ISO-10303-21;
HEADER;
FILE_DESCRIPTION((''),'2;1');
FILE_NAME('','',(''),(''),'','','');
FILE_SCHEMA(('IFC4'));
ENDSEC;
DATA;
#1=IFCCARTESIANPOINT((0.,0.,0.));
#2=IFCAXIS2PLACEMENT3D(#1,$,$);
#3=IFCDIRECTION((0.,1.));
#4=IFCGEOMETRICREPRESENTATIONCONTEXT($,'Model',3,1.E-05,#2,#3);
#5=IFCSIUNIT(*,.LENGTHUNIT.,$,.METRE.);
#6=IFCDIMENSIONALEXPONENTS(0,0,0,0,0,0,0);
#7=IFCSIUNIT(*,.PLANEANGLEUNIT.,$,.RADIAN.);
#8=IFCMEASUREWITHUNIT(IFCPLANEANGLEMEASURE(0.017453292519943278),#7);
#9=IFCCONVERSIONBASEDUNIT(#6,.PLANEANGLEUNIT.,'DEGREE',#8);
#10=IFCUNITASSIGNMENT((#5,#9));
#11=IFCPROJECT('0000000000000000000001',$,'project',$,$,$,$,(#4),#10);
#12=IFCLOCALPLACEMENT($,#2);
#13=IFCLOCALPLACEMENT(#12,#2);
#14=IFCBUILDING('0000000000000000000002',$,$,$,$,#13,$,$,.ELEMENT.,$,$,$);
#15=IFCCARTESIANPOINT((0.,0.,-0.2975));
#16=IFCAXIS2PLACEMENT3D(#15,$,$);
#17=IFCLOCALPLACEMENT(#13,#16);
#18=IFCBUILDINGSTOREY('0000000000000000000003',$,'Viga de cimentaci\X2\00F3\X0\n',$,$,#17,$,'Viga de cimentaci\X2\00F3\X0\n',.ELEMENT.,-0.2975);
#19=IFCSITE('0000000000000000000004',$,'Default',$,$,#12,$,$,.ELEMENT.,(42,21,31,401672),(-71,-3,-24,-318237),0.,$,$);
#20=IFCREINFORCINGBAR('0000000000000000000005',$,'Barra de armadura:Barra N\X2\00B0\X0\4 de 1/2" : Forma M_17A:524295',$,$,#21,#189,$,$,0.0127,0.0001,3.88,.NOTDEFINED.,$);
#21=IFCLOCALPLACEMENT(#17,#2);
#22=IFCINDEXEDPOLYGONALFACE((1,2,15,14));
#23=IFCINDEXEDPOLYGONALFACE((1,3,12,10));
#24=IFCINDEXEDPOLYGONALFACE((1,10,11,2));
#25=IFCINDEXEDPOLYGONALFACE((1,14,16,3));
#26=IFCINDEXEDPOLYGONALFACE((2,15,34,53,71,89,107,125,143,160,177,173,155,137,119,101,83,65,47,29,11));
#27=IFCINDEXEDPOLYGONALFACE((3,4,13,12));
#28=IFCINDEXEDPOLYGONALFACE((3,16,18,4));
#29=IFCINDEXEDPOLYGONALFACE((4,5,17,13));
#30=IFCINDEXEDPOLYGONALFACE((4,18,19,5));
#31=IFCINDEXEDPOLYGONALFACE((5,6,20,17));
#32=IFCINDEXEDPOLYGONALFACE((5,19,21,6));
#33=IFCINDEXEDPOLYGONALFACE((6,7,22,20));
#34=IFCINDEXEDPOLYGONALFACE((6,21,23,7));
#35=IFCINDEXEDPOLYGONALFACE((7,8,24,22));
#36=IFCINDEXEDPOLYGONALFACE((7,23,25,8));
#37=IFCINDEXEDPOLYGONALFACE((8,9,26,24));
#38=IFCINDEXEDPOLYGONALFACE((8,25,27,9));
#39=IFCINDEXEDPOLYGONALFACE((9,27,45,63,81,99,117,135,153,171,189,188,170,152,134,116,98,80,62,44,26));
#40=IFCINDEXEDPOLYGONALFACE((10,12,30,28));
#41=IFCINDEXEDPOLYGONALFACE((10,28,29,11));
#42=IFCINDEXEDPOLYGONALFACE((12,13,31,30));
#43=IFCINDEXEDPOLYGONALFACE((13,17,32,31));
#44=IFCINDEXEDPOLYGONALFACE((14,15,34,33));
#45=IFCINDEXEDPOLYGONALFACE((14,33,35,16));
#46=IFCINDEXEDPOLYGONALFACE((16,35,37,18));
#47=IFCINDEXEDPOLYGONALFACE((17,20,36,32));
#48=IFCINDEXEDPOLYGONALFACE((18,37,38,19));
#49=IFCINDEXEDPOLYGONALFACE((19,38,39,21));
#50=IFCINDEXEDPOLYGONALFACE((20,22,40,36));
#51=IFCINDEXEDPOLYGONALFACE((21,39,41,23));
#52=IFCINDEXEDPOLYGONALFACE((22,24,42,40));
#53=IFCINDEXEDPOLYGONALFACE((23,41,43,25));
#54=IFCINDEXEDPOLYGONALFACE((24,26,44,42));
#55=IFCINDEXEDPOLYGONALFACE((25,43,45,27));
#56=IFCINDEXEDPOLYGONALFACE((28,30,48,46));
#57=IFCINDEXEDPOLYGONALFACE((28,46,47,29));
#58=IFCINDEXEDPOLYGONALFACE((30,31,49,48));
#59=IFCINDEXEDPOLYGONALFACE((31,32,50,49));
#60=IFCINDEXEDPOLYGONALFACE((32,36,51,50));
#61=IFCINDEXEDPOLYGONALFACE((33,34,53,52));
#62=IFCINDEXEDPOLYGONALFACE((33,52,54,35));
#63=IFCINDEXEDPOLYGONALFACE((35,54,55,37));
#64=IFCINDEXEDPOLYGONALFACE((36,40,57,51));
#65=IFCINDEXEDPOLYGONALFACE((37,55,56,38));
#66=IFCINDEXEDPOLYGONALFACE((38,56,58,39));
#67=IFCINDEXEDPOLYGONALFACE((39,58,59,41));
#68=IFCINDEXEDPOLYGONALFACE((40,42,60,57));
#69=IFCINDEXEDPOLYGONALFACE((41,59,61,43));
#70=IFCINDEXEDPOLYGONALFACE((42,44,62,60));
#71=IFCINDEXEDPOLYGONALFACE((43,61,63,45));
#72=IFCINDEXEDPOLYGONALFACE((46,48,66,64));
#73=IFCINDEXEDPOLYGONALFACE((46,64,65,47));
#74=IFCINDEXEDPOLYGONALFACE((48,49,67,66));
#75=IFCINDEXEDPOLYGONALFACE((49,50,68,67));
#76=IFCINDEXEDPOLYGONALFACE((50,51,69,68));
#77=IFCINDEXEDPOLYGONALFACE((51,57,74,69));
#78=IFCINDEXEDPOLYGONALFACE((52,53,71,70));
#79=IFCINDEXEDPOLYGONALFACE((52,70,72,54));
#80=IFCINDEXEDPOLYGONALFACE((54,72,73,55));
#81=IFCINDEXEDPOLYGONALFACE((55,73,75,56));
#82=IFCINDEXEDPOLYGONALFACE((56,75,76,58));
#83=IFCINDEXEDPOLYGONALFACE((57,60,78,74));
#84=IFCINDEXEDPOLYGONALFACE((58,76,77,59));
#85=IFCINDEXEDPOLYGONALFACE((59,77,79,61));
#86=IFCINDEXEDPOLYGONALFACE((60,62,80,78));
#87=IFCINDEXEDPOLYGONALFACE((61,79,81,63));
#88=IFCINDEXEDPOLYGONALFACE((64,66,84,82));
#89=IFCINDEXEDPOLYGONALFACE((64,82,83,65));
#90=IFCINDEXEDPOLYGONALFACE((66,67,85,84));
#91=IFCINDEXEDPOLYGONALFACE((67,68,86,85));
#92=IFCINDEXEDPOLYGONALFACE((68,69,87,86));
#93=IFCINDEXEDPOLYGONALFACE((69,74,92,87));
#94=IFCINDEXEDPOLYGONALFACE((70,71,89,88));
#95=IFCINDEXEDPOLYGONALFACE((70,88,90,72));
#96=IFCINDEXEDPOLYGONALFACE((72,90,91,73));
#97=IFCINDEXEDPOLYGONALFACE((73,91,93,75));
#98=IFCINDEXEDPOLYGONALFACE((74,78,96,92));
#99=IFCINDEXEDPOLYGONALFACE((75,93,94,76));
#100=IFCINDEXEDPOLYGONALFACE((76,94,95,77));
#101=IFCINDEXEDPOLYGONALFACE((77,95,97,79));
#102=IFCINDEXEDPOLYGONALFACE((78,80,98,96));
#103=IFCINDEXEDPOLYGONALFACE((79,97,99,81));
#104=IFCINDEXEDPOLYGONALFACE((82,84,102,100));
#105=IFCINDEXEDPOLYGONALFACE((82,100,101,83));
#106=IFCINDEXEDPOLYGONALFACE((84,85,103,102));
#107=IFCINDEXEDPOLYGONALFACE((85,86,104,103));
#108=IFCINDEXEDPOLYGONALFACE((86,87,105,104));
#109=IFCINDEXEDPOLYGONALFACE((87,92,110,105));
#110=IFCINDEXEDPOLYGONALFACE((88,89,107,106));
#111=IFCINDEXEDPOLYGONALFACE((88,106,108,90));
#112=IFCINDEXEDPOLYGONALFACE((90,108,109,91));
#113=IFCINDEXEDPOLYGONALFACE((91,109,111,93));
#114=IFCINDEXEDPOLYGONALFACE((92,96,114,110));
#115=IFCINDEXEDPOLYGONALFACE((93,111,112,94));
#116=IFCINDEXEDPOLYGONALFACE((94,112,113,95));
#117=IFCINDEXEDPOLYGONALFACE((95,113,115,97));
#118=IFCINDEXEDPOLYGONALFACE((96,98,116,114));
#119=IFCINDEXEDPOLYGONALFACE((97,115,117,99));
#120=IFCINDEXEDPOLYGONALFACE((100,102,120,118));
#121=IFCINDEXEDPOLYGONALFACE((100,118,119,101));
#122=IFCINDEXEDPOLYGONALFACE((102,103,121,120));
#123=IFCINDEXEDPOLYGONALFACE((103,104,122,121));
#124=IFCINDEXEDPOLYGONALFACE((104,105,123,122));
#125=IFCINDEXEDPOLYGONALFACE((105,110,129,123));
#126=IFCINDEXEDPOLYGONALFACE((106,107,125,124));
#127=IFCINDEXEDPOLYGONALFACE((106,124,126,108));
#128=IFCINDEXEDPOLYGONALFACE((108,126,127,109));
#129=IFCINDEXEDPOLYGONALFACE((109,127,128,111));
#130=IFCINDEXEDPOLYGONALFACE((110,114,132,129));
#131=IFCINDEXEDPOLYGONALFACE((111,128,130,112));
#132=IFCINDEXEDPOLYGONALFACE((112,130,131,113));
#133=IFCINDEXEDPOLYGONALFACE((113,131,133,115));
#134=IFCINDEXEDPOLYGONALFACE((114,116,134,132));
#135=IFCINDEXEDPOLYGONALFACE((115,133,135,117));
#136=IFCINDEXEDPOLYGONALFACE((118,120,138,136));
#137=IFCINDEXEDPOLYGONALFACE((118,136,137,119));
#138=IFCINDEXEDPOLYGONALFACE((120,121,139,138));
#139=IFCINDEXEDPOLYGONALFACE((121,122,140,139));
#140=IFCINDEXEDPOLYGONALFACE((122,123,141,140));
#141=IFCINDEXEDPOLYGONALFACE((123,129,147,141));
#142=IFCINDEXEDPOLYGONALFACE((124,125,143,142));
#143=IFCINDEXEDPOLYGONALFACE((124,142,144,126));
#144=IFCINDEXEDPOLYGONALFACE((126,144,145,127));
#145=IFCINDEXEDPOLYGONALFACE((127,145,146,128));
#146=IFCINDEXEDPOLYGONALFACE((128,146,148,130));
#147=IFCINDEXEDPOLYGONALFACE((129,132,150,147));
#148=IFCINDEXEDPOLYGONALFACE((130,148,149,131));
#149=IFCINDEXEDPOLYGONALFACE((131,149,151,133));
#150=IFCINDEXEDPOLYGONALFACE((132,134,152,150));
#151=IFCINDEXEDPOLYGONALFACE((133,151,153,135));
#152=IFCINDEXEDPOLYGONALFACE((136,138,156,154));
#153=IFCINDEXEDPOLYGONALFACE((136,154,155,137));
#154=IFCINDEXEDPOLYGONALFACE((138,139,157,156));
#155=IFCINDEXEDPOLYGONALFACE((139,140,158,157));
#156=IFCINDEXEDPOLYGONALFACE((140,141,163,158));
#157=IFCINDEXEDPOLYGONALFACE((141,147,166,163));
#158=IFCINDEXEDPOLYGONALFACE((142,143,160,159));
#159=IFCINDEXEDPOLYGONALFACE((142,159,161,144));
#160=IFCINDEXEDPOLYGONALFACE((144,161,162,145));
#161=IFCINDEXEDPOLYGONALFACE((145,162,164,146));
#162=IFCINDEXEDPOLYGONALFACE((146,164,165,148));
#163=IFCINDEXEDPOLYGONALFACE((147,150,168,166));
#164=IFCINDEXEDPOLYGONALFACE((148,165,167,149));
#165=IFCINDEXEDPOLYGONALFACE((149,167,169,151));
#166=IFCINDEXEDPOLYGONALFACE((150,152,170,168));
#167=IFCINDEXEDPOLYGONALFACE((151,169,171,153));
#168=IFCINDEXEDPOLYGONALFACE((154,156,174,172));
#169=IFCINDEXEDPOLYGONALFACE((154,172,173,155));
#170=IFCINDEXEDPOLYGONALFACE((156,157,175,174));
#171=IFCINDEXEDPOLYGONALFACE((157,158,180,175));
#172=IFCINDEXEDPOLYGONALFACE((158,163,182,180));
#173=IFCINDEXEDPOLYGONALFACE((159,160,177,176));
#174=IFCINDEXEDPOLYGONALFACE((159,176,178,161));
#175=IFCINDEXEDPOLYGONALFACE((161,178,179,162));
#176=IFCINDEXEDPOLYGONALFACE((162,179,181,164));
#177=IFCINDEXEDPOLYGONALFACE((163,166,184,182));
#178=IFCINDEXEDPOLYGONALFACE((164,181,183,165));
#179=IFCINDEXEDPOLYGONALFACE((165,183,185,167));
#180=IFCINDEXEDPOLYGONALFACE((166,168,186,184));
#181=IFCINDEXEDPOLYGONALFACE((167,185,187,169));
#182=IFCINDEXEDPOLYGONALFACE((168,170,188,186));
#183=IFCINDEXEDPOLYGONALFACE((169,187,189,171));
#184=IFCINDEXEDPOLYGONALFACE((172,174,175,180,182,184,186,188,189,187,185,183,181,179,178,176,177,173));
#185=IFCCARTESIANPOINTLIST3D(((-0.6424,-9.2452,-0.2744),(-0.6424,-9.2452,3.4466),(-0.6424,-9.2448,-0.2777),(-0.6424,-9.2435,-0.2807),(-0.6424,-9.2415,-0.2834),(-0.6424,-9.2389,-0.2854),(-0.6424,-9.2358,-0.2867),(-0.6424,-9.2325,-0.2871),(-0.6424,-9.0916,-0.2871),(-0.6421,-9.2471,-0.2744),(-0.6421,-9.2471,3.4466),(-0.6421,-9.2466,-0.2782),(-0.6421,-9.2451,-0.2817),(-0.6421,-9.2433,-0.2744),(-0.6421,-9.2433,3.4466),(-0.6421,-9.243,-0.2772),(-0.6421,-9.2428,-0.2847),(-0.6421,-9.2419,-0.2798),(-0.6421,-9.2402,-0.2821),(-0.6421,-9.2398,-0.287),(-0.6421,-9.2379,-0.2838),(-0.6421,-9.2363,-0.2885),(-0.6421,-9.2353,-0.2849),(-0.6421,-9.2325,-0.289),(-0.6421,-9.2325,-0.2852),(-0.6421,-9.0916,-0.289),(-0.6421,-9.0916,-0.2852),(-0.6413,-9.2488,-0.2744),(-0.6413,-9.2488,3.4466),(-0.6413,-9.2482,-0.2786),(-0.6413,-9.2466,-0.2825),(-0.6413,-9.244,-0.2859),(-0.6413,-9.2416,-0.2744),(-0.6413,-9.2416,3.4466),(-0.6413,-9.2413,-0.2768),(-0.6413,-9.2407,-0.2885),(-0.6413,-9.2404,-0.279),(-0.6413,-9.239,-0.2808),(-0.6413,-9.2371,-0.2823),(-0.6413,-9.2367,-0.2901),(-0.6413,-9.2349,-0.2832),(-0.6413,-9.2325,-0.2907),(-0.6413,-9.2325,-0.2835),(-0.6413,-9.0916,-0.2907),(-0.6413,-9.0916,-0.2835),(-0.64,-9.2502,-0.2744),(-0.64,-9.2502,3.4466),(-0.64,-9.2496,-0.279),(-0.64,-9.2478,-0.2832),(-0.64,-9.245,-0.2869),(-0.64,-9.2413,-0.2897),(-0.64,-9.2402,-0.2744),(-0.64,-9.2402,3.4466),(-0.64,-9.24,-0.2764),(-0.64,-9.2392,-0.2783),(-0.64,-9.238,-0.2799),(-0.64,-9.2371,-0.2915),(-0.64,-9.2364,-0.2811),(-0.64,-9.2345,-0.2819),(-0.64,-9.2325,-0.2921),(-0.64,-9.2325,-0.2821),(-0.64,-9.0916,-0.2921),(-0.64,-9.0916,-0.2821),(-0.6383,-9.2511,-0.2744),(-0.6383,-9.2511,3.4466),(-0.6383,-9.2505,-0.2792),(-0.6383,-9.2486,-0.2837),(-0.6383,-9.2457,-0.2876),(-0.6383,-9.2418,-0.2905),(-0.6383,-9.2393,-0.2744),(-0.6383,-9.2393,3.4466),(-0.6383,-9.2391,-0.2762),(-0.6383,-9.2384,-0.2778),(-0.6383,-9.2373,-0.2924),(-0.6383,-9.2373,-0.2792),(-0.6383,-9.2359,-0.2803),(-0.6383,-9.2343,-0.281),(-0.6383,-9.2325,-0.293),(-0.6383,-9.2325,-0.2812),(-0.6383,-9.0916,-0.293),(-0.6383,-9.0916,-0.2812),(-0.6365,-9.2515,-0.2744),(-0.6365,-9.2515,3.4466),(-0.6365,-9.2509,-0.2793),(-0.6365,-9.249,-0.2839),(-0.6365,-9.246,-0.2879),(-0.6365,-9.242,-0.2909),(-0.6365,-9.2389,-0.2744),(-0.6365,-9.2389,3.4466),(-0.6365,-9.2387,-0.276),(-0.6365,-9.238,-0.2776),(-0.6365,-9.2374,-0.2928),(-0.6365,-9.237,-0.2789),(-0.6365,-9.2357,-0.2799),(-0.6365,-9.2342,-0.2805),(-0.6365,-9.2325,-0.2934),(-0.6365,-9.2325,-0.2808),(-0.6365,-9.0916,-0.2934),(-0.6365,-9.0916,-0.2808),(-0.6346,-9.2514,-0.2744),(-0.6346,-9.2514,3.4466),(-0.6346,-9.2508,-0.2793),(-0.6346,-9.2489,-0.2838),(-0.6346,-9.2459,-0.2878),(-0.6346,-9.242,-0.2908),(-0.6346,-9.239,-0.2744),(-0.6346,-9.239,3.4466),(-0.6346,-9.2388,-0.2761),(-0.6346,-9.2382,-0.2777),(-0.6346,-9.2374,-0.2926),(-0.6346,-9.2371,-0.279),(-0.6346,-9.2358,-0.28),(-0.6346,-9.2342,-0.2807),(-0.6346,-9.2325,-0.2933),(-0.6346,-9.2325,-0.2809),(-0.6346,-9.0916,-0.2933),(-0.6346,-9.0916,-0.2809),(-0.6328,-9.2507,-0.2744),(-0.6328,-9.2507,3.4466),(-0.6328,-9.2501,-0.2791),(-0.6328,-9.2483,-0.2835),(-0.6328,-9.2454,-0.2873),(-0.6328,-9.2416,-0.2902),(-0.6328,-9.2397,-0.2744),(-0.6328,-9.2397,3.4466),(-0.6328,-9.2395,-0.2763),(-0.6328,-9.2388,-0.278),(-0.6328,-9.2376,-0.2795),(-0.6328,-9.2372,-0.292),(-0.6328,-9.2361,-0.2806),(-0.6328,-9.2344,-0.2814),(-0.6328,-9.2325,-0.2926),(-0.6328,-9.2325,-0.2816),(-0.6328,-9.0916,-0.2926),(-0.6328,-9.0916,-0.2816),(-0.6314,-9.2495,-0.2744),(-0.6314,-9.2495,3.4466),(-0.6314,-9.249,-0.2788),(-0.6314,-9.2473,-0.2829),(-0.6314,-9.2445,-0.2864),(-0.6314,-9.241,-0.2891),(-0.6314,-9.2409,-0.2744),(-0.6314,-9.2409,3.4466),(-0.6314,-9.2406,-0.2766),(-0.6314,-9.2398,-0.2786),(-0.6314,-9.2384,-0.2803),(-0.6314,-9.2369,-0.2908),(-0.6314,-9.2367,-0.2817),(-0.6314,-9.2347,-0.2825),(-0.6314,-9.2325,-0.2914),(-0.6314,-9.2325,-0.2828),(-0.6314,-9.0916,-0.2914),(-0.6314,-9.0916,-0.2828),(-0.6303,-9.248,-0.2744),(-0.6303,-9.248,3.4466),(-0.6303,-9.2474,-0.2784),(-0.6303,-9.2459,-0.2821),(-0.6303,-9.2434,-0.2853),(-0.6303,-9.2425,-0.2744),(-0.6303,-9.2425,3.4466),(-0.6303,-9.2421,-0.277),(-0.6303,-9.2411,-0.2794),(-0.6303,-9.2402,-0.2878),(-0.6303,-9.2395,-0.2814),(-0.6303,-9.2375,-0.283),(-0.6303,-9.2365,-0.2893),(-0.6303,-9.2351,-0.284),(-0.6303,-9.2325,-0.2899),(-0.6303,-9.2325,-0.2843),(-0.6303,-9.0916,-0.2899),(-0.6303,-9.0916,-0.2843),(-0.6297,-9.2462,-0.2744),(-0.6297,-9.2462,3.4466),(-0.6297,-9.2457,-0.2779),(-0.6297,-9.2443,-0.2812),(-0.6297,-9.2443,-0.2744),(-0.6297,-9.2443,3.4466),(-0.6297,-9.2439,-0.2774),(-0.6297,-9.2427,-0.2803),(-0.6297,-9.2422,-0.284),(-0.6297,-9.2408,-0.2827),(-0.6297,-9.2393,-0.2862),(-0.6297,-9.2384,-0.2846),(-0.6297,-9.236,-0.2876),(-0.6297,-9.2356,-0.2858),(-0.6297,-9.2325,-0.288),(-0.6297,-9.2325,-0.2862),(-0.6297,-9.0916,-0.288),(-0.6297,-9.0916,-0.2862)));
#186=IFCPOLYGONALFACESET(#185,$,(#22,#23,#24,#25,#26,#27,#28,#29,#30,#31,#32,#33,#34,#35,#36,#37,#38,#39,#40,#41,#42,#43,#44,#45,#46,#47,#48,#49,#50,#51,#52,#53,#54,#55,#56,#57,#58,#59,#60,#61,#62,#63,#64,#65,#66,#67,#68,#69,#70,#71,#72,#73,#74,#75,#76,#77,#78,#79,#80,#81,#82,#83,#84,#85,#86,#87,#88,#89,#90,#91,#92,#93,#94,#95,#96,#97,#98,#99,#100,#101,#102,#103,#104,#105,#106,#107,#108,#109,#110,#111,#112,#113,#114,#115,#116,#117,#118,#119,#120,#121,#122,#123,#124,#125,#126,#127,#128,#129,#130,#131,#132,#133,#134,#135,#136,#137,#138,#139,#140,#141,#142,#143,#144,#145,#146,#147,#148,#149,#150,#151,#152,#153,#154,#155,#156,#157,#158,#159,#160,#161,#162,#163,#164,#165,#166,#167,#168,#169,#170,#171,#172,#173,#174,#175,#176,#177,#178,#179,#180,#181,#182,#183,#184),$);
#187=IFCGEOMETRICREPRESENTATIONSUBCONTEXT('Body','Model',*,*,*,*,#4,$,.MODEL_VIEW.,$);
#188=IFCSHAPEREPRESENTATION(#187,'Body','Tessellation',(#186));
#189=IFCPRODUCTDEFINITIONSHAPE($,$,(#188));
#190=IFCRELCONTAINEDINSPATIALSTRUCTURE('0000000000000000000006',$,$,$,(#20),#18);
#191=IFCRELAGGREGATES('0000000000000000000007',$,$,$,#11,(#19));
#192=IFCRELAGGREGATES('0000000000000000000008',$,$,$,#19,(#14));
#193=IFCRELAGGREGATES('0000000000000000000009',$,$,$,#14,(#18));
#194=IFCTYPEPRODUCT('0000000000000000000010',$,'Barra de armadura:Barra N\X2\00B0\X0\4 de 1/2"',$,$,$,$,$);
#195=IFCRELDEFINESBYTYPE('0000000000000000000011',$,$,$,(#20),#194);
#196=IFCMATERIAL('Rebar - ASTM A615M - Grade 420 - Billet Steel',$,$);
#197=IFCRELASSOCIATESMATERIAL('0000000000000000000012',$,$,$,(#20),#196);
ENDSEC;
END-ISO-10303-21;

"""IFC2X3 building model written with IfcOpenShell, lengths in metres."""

from ifc_helpers import new_model, entity, si_unit, converted_unit, direction, frame, origin, place, context, subcontext, project, spatial, material, type_object, element, save


model = new_model("IFC2X3")

# Units and contexts
model_context = context("Model", 3, precision=1e-05, world=origin(), true_north=direction((0.0, 1.0)))
body_context = subcontext(model_context, "Body", "Model", "MODEL_VIEW")
ifc_project = project(units=[si_unit("LENGTHUNIT", "METRE"), converted_unit("PLANEANGLEUNIT", "DEGREE", entity("IfcPlaneAngleMeasure", 0.017453292519943278), si_unit("PLANEANGLEUNIT", "RADIAN"), dimensions=[0, 0, 0, 0, 0, 0, 0])], contexts=[model_context])

# Site, building, storey
site_placement = place(None, origin())
site = spatial("IfcSite", under=ifc_project, at=site_placement, Name="Default", CompositionType="ELEMENT", RefLatitude=(42, 21, 31, 401672), RefLongitude=(-71, -3, -24, -318237), RefElevation=0.0)
building_placement = place(site_placement, origin())
building = spatial("IfcBuilding", under=site, at=building_placement, CompositionType="ELEMENT")
storey_placement = place(building_placement, frame((0.0, 0.0, -0.2975)))
storey = spatial("IfcBuildingStorey", under=building, at=storey_placement, Name="Viga de cimentación", LongName="Viga de cimentación", CompositionType="ELEMENT", Elevation=-0.2975)

# Reinforcing bar
ifc_material = material(Name="Rebar - ASTM A615M - Grade 420 - Billet Steel")
type_product_1 = type_object("IfcTypeProduct", Name="Barra de armadura:Barra N°4 de 1/2\"")
reinforcing_bar_1_placement = place(storey_placement, origin())
element("IfcReinforcingBar", 1, at=reinforcing_bar_1_placement, inside=storey, type_object=type_product_1, material=ifc_material, Name="Barra de armadura:Barra N°4 de 1/2\" : Forma M_17A:524295", BarLength=3.88, BarRole="NOTDEFINED", CrossSectionArea=0.0001, NominalDiameter=0.0127, context=body_context, shape_type="AdvancedSweptSolid", body=[
    entity("IfcSweptDiskSolid", entity("IfcCompositeCurve", [entity("IfcCompositeCurveSegment", "CONTINUOUS", True, entity("IfcPolyline", [entity("IfcCartesianPoint", [-0.636, -9.2452, 3.4466]), entity("IfcCartesianPoint", [-0.636, -9.2452, -0.2744])])), entity("IfcCompositeCurveSegment", "CONTINUOUS", True, entity("IfcTrimmedCurve", entity("IfcCircle", entity("IfcAxis2Placement3D", entity("IfcCartesianPoint", [-0.636, -9.2325, -0.2744]), entity("IfcDirection", [1.0, 0.0, 0.0]), entity("IfcDirection", [0.0, 0.0, -1.0])), 0.0127), [entity("IfcParameterValue", 270.0)], [entity("IfcParameterValue", 360.0)], True, "PARAMETER")), entity("IfcCompositeCurveSegment", "CONTINUOUS", True, entity("IfcPolyline", [entity("IfcCartesianPoint", [-0.636, -9.2325, -0.2871]), entity("IfcCartesianPoint", [-0.636, -9.0916, -0.2871])]))], False), 0.0063, None, 0.0, 92.0),
])

save(model, "model.ifc")
